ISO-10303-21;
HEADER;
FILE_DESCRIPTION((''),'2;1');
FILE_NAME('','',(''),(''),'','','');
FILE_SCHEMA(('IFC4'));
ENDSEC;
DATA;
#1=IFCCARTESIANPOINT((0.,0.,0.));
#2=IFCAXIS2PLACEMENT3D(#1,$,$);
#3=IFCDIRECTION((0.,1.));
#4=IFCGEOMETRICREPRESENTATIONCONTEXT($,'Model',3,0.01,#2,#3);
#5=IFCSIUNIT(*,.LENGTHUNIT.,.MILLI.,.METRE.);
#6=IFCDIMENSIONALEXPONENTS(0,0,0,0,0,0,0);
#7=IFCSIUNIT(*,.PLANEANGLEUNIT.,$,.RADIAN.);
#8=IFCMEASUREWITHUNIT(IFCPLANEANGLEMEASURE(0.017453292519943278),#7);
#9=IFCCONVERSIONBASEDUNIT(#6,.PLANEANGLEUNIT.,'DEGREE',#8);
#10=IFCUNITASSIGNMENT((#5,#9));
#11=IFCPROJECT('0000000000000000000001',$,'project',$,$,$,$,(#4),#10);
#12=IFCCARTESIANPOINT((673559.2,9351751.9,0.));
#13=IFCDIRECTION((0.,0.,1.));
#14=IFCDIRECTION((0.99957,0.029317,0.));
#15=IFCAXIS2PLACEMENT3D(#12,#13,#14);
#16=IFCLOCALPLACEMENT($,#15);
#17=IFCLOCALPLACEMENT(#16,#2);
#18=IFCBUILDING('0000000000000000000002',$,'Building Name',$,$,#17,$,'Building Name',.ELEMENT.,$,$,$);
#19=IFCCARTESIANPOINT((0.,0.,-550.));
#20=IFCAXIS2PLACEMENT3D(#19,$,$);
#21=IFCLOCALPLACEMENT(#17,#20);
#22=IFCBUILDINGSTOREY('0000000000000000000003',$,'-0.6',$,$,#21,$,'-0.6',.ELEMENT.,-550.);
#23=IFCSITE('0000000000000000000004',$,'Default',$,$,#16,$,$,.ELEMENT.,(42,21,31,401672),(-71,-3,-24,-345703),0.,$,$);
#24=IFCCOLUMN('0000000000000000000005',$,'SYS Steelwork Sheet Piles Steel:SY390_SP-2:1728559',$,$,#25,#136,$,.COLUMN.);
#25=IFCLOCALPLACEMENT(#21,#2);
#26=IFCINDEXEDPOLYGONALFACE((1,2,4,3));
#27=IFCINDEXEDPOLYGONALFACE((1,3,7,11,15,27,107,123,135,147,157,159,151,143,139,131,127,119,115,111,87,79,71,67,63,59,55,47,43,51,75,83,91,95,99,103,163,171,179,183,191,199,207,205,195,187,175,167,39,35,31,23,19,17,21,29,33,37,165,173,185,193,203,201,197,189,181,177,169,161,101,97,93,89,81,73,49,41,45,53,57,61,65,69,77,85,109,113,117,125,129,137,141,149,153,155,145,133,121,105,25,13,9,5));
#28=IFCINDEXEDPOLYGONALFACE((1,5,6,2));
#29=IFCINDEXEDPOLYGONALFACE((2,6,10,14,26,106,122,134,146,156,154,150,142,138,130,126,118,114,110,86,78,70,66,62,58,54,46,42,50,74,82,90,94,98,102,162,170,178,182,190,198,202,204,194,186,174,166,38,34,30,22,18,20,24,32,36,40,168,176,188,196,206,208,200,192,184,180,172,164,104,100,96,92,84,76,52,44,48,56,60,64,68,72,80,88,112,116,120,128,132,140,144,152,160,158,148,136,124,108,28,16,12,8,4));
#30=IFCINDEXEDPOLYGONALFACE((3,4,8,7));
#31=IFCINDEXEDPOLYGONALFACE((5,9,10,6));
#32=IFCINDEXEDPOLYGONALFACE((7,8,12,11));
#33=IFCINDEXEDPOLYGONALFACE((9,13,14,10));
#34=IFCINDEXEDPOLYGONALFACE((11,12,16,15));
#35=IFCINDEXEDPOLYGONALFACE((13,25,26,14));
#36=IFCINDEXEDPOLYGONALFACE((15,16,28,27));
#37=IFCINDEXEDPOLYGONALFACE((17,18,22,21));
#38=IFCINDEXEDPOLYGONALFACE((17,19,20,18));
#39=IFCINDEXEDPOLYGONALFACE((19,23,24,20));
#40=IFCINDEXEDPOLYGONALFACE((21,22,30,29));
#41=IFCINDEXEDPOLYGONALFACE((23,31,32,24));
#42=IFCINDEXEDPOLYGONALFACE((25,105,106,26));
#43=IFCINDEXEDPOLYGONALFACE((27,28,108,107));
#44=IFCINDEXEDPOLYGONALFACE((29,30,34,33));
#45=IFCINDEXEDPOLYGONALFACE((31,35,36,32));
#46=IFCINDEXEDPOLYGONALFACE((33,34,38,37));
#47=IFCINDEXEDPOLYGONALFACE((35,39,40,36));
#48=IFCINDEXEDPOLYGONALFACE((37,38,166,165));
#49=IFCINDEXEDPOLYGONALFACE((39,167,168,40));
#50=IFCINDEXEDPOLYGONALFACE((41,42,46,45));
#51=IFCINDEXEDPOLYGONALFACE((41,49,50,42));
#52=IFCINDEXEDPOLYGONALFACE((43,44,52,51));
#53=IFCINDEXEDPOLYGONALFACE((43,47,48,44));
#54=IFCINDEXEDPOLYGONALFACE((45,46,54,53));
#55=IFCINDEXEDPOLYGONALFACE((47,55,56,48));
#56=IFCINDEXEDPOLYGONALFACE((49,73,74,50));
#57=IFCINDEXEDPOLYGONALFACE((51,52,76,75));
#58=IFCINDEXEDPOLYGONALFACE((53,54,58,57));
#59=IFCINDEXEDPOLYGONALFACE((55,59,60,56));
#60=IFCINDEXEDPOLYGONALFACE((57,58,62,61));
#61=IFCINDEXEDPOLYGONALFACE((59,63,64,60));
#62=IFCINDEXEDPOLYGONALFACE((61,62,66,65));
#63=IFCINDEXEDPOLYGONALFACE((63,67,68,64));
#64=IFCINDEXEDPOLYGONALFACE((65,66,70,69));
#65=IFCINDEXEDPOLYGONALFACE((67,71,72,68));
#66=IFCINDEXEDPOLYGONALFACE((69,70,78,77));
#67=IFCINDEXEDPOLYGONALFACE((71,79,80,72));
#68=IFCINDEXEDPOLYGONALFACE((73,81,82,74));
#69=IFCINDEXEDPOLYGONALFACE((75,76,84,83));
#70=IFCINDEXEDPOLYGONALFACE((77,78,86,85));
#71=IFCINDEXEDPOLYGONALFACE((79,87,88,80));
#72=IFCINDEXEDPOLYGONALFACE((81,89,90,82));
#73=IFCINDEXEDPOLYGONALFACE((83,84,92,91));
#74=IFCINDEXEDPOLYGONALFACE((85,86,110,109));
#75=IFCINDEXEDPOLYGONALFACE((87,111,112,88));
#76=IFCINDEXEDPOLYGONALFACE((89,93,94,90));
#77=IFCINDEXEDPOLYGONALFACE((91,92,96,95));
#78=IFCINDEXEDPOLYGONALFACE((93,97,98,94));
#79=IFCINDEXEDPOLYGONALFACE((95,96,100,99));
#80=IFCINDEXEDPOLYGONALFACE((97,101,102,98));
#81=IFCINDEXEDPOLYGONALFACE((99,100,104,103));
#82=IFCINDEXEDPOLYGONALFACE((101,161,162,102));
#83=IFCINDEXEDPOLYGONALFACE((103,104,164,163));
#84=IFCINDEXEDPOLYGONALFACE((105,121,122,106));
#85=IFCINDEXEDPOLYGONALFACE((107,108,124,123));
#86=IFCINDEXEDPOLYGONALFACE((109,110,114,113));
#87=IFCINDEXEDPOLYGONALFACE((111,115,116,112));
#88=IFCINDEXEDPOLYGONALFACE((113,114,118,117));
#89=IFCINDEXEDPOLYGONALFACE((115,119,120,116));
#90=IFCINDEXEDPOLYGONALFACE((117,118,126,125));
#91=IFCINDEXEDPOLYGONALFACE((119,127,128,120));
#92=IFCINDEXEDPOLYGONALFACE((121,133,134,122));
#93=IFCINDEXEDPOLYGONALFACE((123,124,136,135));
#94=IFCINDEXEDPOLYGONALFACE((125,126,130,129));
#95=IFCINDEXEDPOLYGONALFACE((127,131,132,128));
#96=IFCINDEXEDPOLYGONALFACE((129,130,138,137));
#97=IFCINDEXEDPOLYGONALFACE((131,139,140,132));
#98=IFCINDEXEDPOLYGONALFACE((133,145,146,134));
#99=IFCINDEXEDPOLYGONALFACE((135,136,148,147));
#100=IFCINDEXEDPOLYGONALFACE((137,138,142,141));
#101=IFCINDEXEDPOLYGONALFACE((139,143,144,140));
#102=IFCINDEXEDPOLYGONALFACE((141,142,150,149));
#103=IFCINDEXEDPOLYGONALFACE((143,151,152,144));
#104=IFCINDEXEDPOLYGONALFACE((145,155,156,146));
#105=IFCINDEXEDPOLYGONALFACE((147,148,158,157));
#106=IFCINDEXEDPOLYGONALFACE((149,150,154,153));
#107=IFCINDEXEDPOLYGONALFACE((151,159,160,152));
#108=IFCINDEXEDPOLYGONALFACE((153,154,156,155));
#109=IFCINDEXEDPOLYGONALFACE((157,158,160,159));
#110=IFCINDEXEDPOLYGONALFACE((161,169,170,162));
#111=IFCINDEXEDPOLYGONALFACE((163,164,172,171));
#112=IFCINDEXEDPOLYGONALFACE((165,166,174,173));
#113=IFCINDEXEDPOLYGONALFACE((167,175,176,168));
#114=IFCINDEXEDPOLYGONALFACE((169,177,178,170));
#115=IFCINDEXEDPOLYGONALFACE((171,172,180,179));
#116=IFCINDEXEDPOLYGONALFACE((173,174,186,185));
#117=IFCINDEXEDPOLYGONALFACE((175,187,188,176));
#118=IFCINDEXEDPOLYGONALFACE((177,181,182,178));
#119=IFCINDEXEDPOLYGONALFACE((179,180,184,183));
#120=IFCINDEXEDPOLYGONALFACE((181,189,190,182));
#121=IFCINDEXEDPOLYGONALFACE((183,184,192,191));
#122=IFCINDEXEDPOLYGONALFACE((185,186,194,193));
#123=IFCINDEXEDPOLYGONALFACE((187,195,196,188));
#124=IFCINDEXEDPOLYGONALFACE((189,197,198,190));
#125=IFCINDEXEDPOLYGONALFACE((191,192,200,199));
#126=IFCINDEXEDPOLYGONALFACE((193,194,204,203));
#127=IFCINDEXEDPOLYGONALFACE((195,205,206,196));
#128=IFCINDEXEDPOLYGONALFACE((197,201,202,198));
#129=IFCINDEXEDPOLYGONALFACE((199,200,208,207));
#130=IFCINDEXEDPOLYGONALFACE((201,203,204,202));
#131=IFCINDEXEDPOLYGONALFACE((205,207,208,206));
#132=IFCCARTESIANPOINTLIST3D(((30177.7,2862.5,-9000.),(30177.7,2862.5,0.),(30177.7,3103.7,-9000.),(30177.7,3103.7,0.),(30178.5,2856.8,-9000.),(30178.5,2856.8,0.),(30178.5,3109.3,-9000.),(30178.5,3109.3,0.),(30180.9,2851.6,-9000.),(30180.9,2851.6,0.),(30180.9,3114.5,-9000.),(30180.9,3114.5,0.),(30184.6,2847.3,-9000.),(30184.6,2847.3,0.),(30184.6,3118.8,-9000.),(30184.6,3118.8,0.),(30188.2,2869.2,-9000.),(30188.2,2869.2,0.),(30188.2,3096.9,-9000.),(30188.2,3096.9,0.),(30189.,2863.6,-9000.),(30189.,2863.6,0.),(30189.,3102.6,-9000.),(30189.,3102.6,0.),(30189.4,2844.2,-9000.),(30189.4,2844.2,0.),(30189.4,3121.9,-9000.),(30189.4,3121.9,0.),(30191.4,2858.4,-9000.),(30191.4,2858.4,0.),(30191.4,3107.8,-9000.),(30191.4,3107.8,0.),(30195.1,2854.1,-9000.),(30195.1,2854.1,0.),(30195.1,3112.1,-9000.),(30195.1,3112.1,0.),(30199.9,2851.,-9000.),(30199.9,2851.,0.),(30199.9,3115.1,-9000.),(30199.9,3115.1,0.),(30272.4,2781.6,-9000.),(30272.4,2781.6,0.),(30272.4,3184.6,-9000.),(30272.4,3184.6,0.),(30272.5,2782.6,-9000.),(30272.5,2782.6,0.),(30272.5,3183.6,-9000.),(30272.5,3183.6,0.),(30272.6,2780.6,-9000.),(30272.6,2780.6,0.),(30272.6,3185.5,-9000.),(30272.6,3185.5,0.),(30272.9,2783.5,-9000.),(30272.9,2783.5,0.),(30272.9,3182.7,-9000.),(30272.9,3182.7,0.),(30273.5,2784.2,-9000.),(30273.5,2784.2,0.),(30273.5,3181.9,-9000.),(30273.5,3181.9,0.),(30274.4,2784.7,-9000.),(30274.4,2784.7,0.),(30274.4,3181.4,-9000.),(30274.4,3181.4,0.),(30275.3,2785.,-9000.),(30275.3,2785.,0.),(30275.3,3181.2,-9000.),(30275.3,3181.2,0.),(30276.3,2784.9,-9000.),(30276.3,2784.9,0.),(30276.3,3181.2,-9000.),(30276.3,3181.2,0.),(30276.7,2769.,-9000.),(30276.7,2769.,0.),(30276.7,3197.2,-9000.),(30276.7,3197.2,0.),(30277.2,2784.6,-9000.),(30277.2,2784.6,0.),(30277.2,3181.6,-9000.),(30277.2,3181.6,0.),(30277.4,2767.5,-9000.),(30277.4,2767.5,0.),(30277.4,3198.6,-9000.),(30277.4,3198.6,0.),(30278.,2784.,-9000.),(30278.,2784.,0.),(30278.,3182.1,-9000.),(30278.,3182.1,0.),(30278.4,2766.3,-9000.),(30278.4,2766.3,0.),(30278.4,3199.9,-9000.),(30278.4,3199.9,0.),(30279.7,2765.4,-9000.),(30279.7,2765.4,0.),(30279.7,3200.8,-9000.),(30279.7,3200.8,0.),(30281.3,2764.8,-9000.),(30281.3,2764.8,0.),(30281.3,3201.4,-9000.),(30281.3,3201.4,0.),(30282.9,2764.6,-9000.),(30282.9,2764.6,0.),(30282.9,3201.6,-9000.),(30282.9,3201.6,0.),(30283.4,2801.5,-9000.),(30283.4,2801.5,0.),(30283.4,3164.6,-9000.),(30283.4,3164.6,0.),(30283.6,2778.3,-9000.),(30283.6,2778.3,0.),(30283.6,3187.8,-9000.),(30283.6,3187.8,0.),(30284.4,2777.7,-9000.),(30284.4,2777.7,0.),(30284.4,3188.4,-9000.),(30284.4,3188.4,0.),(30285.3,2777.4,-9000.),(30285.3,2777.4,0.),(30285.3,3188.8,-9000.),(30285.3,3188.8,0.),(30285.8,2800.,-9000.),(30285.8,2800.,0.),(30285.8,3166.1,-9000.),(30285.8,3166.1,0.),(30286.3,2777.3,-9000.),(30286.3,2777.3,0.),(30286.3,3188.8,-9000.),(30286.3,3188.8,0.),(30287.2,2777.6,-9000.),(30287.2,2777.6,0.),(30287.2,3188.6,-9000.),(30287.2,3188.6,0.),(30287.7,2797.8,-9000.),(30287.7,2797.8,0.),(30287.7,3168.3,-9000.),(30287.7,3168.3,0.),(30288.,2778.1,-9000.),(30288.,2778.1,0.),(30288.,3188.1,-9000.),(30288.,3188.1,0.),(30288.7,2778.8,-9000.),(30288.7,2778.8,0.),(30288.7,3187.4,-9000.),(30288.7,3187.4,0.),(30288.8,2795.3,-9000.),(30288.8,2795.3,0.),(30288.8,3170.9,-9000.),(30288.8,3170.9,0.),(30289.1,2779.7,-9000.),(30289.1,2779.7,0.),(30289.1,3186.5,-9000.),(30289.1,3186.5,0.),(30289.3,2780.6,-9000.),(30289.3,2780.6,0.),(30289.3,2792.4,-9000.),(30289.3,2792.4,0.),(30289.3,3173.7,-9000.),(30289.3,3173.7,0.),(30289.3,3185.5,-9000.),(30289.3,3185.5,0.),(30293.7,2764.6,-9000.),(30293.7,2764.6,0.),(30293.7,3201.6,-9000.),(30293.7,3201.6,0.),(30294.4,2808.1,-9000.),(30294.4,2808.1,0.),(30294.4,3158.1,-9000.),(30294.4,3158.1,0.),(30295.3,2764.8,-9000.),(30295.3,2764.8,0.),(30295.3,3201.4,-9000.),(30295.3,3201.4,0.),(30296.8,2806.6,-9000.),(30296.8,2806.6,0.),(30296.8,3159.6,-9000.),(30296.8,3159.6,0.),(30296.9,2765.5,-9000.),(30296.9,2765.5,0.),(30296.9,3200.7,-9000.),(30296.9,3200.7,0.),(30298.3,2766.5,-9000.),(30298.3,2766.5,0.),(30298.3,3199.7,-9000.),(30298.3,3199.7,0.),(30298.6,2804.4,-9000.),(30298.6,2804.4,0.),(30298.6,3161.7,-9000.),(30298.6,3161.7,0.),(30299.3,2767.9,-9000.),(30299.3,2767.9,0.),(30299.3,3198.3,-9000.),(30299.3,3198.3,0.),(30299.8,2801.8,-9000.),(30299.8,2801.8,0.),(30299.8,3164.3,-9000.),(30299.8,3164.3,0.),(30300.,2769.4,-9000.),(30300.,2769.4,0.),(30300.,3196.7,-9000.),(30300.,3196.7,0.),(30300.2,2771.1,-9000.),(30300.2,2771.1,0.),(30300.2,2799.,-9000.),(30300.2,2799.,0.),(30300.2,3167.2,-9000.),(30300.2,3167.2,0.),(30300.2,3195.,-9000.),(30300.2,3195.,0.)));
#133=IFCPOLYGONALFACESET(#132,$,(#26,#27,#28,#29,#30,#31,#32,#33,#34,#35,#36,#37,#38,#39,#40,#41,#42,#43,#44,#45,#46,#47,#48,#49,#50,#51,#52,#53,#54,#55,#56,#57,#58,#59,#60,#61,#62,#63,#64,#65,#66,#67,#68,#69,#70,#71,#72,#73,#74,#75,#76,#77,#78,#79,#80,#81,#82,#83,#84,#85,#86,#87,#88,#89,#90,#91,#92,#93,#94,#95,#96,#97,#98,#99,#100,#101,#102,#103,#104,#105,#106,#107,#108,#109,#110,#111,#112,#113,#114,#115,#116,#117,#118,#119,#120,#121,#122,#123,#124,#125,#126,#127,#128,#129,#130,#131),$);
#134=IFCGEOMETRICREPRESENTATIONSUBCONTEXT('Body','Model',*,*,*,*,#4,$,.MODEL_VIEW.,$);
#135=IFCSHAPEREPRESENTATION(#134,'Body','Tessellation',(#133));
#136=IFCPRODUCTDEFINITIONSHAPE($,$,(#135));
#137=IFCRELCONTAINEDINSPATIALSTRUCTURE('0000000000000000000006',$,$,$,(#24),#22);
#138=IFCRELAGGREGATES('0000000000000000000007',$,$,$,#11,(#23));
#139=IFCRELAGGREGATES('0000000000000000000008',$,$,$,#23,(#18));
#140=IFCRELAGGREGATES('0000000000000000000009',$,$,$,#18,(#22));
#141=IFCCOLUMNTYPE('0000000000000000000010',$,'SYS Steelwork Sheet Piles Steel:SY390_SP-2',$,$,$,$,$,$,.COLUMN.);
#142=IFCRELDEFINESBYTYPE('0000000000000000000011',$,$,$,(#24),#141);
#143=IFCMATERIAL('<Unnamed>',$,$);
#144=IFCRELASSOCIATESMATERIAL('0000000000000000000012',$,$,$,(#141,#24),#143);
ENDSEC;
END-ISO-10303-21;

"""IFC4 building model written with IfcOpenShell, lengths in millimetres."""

from ifc_helpers import new_model, entity, si_unit, converted_unit, direction, frame, origin, place, context, subcontext, project, spatial, line, arc, indexed_curve, outline, extrude, source, transform, mapped, material, type_object, type_shapes, element, save


model = new_model("IFC4")

# Units and contexts
model_context = context("Model", 3, precision=0.01, world=origin(), true_north=direction((0.0, 1.0)))
body_context = subcontext(model_context, "Body", "Model", "MODEL_VIEW")
ifc_project = project(units=[si_unit("LENGTHUNIT", "METRE", prefix="MILLI"), converted_unit("PLANEANGLEUNIT", "DEGREE", entity("IfcPlaneAngleMeasure", 0.017453292519943278), si_unit("PLANEANGLEUNIT", "RADIAN"), dimensions=[0, 0, 0, 0, 0, 0, 0])], contexts=[model_context])

# Site, building, storey
site_placement = place(None, frame((673559.2, 9351751.9, 0.0), z_axis=(0.0, 0.0, 1.0), x_axis=(0.99957, 0.029317, 0.0)))
site = spatial("IfcSite", under=ifc_project, at=site_placement, Name="Default", CompositionType="ELEMENT", RefLatitude=(42, 21, 31, 401672), RefLongitude=(-71, -3, -24, -345703), RefElevation=0.0)
building_placement = place(site_placement, origin())
building = spatial("IfcBuilding", under=site, at=building_placement, Name="Building Name", LongName="Building Name", CompositionType="ELEMENT")
storey_placement = place(building_placement, frame((0.0, 0.0, -550.0)))
storey = spatial("IfcBuildingStorey", under=building, at=storey_placement, Name="-0.6", LongName="-0.6", CompositionType="ELEMENT", Elevation=-550.0)

# Column
ifc_material_1 = material(Name="<Unnamed>")
column_type = type_object("IfcColumnType", Name="SYS Steelwork Sheet Piles Steel:SY390_SP-2", PredefinedType="COLUMN", material=ifc_material_1)
shared_shape_1 = source(origin(), body_context, "Body", "SweptSolid", [
    extrude(outline(indexed_curve([(-120.6, 84.7), (-131.4, 81.6), (-138.8, 73.0), (-181.5, -20.9), (-185.2, -25.2), (-190.6, -26.8), (-202.5, -26.8), (-205.5, -24.8), (-204.8, -21.2), (-199.1, -15.5), (-198.6, -11.5), (-202.5, -10.1), (-214.1, -14.2), (-217.3, -16.6), (-218.5, -20.4), (-218.5, -31.2), (-216.6, -35.8), (-211.9, -37.8), (-184.1, -37.8), (-178.7, -36.2), (-175.0, -31.9), (-132.1, 62.5), (-124.7, 71.1), (-113.9, 74.2), (113.9, 74.2), (124.7, 71.1), (132.1, 62.5), (175.0, -31.9), (178.7, -36.2), (184.1, -37.8), (211.9, -37.8), (216.6, -35.8), (218.5, -31.2), (218.5, -20.4), (217.3, -16.6), (214.1, -14.2), (202.5, -10.1), (198.6, -11.5), (199.1, -15.5), (204.8, -21.2), (205.5, -24.8), (202.5, -26.8), (190.6, -26.8), (185.2, -25.2), (181.5, -20.9), (138.8, 73.0), (131.4, 81.6), (120.6, 84.7)], segments=[arc(1, 2, 3), line(3, 4), arc(4, 5, 6), line(6, 7), arc(7, 8, 9), line(9, 10), arc(10, 11, 12), line(12, 13), arc(13, 14, 15), line(15, 16), arc(16, 17, 18), line(18, 19), arc(19, 20, 21), line(21, 22), arc(22, 23, 24), line(24, 25), arc(25, 26, 27), line(27, 28), arc(28, 29, 30), line(30, 31), arc(31, 32, 33), line(33, 34), arc(34, 35, 36), line(36, 37), arc(37, 38, 39), line(39, 40), arc(40, 41, 42), line(42, 43), arc(43, 44, 45), line(45, 46), arc(46, 47, 48), line(48, 1)], self_intersect=False)), frame((0.0, 15.3, -9550.0)), (0.0, 0.0, 1.0), 9000.0),
])
type_shapes(column_type, [shared_shape_1])
for number, where, z_axis, x_axis, name in (
    (1, (30277.7, 2983.1, 550.0), (0.0, 0.0, 1.0), (0.0, 1.0, 0.0), "SYS Steelwork Sheet Piles Steel:SY390_SP-2:1728559"),
):
    element("IfcColumn", number, at=place(storey_placement, frame(where, z_axis=z_axis, x_axis=x_axis)), inside=storey, type_object=column_type, material=ifc_material_1, Name=name, PredefinedType="COLUMN", context=body_context, shape_type="MappedRepresentation", body=[
        mapped(shared_shape_1, transform((0.0, 0.0, 0.0), scale=1.0)),
    ])

save(model, "model.ifc")
